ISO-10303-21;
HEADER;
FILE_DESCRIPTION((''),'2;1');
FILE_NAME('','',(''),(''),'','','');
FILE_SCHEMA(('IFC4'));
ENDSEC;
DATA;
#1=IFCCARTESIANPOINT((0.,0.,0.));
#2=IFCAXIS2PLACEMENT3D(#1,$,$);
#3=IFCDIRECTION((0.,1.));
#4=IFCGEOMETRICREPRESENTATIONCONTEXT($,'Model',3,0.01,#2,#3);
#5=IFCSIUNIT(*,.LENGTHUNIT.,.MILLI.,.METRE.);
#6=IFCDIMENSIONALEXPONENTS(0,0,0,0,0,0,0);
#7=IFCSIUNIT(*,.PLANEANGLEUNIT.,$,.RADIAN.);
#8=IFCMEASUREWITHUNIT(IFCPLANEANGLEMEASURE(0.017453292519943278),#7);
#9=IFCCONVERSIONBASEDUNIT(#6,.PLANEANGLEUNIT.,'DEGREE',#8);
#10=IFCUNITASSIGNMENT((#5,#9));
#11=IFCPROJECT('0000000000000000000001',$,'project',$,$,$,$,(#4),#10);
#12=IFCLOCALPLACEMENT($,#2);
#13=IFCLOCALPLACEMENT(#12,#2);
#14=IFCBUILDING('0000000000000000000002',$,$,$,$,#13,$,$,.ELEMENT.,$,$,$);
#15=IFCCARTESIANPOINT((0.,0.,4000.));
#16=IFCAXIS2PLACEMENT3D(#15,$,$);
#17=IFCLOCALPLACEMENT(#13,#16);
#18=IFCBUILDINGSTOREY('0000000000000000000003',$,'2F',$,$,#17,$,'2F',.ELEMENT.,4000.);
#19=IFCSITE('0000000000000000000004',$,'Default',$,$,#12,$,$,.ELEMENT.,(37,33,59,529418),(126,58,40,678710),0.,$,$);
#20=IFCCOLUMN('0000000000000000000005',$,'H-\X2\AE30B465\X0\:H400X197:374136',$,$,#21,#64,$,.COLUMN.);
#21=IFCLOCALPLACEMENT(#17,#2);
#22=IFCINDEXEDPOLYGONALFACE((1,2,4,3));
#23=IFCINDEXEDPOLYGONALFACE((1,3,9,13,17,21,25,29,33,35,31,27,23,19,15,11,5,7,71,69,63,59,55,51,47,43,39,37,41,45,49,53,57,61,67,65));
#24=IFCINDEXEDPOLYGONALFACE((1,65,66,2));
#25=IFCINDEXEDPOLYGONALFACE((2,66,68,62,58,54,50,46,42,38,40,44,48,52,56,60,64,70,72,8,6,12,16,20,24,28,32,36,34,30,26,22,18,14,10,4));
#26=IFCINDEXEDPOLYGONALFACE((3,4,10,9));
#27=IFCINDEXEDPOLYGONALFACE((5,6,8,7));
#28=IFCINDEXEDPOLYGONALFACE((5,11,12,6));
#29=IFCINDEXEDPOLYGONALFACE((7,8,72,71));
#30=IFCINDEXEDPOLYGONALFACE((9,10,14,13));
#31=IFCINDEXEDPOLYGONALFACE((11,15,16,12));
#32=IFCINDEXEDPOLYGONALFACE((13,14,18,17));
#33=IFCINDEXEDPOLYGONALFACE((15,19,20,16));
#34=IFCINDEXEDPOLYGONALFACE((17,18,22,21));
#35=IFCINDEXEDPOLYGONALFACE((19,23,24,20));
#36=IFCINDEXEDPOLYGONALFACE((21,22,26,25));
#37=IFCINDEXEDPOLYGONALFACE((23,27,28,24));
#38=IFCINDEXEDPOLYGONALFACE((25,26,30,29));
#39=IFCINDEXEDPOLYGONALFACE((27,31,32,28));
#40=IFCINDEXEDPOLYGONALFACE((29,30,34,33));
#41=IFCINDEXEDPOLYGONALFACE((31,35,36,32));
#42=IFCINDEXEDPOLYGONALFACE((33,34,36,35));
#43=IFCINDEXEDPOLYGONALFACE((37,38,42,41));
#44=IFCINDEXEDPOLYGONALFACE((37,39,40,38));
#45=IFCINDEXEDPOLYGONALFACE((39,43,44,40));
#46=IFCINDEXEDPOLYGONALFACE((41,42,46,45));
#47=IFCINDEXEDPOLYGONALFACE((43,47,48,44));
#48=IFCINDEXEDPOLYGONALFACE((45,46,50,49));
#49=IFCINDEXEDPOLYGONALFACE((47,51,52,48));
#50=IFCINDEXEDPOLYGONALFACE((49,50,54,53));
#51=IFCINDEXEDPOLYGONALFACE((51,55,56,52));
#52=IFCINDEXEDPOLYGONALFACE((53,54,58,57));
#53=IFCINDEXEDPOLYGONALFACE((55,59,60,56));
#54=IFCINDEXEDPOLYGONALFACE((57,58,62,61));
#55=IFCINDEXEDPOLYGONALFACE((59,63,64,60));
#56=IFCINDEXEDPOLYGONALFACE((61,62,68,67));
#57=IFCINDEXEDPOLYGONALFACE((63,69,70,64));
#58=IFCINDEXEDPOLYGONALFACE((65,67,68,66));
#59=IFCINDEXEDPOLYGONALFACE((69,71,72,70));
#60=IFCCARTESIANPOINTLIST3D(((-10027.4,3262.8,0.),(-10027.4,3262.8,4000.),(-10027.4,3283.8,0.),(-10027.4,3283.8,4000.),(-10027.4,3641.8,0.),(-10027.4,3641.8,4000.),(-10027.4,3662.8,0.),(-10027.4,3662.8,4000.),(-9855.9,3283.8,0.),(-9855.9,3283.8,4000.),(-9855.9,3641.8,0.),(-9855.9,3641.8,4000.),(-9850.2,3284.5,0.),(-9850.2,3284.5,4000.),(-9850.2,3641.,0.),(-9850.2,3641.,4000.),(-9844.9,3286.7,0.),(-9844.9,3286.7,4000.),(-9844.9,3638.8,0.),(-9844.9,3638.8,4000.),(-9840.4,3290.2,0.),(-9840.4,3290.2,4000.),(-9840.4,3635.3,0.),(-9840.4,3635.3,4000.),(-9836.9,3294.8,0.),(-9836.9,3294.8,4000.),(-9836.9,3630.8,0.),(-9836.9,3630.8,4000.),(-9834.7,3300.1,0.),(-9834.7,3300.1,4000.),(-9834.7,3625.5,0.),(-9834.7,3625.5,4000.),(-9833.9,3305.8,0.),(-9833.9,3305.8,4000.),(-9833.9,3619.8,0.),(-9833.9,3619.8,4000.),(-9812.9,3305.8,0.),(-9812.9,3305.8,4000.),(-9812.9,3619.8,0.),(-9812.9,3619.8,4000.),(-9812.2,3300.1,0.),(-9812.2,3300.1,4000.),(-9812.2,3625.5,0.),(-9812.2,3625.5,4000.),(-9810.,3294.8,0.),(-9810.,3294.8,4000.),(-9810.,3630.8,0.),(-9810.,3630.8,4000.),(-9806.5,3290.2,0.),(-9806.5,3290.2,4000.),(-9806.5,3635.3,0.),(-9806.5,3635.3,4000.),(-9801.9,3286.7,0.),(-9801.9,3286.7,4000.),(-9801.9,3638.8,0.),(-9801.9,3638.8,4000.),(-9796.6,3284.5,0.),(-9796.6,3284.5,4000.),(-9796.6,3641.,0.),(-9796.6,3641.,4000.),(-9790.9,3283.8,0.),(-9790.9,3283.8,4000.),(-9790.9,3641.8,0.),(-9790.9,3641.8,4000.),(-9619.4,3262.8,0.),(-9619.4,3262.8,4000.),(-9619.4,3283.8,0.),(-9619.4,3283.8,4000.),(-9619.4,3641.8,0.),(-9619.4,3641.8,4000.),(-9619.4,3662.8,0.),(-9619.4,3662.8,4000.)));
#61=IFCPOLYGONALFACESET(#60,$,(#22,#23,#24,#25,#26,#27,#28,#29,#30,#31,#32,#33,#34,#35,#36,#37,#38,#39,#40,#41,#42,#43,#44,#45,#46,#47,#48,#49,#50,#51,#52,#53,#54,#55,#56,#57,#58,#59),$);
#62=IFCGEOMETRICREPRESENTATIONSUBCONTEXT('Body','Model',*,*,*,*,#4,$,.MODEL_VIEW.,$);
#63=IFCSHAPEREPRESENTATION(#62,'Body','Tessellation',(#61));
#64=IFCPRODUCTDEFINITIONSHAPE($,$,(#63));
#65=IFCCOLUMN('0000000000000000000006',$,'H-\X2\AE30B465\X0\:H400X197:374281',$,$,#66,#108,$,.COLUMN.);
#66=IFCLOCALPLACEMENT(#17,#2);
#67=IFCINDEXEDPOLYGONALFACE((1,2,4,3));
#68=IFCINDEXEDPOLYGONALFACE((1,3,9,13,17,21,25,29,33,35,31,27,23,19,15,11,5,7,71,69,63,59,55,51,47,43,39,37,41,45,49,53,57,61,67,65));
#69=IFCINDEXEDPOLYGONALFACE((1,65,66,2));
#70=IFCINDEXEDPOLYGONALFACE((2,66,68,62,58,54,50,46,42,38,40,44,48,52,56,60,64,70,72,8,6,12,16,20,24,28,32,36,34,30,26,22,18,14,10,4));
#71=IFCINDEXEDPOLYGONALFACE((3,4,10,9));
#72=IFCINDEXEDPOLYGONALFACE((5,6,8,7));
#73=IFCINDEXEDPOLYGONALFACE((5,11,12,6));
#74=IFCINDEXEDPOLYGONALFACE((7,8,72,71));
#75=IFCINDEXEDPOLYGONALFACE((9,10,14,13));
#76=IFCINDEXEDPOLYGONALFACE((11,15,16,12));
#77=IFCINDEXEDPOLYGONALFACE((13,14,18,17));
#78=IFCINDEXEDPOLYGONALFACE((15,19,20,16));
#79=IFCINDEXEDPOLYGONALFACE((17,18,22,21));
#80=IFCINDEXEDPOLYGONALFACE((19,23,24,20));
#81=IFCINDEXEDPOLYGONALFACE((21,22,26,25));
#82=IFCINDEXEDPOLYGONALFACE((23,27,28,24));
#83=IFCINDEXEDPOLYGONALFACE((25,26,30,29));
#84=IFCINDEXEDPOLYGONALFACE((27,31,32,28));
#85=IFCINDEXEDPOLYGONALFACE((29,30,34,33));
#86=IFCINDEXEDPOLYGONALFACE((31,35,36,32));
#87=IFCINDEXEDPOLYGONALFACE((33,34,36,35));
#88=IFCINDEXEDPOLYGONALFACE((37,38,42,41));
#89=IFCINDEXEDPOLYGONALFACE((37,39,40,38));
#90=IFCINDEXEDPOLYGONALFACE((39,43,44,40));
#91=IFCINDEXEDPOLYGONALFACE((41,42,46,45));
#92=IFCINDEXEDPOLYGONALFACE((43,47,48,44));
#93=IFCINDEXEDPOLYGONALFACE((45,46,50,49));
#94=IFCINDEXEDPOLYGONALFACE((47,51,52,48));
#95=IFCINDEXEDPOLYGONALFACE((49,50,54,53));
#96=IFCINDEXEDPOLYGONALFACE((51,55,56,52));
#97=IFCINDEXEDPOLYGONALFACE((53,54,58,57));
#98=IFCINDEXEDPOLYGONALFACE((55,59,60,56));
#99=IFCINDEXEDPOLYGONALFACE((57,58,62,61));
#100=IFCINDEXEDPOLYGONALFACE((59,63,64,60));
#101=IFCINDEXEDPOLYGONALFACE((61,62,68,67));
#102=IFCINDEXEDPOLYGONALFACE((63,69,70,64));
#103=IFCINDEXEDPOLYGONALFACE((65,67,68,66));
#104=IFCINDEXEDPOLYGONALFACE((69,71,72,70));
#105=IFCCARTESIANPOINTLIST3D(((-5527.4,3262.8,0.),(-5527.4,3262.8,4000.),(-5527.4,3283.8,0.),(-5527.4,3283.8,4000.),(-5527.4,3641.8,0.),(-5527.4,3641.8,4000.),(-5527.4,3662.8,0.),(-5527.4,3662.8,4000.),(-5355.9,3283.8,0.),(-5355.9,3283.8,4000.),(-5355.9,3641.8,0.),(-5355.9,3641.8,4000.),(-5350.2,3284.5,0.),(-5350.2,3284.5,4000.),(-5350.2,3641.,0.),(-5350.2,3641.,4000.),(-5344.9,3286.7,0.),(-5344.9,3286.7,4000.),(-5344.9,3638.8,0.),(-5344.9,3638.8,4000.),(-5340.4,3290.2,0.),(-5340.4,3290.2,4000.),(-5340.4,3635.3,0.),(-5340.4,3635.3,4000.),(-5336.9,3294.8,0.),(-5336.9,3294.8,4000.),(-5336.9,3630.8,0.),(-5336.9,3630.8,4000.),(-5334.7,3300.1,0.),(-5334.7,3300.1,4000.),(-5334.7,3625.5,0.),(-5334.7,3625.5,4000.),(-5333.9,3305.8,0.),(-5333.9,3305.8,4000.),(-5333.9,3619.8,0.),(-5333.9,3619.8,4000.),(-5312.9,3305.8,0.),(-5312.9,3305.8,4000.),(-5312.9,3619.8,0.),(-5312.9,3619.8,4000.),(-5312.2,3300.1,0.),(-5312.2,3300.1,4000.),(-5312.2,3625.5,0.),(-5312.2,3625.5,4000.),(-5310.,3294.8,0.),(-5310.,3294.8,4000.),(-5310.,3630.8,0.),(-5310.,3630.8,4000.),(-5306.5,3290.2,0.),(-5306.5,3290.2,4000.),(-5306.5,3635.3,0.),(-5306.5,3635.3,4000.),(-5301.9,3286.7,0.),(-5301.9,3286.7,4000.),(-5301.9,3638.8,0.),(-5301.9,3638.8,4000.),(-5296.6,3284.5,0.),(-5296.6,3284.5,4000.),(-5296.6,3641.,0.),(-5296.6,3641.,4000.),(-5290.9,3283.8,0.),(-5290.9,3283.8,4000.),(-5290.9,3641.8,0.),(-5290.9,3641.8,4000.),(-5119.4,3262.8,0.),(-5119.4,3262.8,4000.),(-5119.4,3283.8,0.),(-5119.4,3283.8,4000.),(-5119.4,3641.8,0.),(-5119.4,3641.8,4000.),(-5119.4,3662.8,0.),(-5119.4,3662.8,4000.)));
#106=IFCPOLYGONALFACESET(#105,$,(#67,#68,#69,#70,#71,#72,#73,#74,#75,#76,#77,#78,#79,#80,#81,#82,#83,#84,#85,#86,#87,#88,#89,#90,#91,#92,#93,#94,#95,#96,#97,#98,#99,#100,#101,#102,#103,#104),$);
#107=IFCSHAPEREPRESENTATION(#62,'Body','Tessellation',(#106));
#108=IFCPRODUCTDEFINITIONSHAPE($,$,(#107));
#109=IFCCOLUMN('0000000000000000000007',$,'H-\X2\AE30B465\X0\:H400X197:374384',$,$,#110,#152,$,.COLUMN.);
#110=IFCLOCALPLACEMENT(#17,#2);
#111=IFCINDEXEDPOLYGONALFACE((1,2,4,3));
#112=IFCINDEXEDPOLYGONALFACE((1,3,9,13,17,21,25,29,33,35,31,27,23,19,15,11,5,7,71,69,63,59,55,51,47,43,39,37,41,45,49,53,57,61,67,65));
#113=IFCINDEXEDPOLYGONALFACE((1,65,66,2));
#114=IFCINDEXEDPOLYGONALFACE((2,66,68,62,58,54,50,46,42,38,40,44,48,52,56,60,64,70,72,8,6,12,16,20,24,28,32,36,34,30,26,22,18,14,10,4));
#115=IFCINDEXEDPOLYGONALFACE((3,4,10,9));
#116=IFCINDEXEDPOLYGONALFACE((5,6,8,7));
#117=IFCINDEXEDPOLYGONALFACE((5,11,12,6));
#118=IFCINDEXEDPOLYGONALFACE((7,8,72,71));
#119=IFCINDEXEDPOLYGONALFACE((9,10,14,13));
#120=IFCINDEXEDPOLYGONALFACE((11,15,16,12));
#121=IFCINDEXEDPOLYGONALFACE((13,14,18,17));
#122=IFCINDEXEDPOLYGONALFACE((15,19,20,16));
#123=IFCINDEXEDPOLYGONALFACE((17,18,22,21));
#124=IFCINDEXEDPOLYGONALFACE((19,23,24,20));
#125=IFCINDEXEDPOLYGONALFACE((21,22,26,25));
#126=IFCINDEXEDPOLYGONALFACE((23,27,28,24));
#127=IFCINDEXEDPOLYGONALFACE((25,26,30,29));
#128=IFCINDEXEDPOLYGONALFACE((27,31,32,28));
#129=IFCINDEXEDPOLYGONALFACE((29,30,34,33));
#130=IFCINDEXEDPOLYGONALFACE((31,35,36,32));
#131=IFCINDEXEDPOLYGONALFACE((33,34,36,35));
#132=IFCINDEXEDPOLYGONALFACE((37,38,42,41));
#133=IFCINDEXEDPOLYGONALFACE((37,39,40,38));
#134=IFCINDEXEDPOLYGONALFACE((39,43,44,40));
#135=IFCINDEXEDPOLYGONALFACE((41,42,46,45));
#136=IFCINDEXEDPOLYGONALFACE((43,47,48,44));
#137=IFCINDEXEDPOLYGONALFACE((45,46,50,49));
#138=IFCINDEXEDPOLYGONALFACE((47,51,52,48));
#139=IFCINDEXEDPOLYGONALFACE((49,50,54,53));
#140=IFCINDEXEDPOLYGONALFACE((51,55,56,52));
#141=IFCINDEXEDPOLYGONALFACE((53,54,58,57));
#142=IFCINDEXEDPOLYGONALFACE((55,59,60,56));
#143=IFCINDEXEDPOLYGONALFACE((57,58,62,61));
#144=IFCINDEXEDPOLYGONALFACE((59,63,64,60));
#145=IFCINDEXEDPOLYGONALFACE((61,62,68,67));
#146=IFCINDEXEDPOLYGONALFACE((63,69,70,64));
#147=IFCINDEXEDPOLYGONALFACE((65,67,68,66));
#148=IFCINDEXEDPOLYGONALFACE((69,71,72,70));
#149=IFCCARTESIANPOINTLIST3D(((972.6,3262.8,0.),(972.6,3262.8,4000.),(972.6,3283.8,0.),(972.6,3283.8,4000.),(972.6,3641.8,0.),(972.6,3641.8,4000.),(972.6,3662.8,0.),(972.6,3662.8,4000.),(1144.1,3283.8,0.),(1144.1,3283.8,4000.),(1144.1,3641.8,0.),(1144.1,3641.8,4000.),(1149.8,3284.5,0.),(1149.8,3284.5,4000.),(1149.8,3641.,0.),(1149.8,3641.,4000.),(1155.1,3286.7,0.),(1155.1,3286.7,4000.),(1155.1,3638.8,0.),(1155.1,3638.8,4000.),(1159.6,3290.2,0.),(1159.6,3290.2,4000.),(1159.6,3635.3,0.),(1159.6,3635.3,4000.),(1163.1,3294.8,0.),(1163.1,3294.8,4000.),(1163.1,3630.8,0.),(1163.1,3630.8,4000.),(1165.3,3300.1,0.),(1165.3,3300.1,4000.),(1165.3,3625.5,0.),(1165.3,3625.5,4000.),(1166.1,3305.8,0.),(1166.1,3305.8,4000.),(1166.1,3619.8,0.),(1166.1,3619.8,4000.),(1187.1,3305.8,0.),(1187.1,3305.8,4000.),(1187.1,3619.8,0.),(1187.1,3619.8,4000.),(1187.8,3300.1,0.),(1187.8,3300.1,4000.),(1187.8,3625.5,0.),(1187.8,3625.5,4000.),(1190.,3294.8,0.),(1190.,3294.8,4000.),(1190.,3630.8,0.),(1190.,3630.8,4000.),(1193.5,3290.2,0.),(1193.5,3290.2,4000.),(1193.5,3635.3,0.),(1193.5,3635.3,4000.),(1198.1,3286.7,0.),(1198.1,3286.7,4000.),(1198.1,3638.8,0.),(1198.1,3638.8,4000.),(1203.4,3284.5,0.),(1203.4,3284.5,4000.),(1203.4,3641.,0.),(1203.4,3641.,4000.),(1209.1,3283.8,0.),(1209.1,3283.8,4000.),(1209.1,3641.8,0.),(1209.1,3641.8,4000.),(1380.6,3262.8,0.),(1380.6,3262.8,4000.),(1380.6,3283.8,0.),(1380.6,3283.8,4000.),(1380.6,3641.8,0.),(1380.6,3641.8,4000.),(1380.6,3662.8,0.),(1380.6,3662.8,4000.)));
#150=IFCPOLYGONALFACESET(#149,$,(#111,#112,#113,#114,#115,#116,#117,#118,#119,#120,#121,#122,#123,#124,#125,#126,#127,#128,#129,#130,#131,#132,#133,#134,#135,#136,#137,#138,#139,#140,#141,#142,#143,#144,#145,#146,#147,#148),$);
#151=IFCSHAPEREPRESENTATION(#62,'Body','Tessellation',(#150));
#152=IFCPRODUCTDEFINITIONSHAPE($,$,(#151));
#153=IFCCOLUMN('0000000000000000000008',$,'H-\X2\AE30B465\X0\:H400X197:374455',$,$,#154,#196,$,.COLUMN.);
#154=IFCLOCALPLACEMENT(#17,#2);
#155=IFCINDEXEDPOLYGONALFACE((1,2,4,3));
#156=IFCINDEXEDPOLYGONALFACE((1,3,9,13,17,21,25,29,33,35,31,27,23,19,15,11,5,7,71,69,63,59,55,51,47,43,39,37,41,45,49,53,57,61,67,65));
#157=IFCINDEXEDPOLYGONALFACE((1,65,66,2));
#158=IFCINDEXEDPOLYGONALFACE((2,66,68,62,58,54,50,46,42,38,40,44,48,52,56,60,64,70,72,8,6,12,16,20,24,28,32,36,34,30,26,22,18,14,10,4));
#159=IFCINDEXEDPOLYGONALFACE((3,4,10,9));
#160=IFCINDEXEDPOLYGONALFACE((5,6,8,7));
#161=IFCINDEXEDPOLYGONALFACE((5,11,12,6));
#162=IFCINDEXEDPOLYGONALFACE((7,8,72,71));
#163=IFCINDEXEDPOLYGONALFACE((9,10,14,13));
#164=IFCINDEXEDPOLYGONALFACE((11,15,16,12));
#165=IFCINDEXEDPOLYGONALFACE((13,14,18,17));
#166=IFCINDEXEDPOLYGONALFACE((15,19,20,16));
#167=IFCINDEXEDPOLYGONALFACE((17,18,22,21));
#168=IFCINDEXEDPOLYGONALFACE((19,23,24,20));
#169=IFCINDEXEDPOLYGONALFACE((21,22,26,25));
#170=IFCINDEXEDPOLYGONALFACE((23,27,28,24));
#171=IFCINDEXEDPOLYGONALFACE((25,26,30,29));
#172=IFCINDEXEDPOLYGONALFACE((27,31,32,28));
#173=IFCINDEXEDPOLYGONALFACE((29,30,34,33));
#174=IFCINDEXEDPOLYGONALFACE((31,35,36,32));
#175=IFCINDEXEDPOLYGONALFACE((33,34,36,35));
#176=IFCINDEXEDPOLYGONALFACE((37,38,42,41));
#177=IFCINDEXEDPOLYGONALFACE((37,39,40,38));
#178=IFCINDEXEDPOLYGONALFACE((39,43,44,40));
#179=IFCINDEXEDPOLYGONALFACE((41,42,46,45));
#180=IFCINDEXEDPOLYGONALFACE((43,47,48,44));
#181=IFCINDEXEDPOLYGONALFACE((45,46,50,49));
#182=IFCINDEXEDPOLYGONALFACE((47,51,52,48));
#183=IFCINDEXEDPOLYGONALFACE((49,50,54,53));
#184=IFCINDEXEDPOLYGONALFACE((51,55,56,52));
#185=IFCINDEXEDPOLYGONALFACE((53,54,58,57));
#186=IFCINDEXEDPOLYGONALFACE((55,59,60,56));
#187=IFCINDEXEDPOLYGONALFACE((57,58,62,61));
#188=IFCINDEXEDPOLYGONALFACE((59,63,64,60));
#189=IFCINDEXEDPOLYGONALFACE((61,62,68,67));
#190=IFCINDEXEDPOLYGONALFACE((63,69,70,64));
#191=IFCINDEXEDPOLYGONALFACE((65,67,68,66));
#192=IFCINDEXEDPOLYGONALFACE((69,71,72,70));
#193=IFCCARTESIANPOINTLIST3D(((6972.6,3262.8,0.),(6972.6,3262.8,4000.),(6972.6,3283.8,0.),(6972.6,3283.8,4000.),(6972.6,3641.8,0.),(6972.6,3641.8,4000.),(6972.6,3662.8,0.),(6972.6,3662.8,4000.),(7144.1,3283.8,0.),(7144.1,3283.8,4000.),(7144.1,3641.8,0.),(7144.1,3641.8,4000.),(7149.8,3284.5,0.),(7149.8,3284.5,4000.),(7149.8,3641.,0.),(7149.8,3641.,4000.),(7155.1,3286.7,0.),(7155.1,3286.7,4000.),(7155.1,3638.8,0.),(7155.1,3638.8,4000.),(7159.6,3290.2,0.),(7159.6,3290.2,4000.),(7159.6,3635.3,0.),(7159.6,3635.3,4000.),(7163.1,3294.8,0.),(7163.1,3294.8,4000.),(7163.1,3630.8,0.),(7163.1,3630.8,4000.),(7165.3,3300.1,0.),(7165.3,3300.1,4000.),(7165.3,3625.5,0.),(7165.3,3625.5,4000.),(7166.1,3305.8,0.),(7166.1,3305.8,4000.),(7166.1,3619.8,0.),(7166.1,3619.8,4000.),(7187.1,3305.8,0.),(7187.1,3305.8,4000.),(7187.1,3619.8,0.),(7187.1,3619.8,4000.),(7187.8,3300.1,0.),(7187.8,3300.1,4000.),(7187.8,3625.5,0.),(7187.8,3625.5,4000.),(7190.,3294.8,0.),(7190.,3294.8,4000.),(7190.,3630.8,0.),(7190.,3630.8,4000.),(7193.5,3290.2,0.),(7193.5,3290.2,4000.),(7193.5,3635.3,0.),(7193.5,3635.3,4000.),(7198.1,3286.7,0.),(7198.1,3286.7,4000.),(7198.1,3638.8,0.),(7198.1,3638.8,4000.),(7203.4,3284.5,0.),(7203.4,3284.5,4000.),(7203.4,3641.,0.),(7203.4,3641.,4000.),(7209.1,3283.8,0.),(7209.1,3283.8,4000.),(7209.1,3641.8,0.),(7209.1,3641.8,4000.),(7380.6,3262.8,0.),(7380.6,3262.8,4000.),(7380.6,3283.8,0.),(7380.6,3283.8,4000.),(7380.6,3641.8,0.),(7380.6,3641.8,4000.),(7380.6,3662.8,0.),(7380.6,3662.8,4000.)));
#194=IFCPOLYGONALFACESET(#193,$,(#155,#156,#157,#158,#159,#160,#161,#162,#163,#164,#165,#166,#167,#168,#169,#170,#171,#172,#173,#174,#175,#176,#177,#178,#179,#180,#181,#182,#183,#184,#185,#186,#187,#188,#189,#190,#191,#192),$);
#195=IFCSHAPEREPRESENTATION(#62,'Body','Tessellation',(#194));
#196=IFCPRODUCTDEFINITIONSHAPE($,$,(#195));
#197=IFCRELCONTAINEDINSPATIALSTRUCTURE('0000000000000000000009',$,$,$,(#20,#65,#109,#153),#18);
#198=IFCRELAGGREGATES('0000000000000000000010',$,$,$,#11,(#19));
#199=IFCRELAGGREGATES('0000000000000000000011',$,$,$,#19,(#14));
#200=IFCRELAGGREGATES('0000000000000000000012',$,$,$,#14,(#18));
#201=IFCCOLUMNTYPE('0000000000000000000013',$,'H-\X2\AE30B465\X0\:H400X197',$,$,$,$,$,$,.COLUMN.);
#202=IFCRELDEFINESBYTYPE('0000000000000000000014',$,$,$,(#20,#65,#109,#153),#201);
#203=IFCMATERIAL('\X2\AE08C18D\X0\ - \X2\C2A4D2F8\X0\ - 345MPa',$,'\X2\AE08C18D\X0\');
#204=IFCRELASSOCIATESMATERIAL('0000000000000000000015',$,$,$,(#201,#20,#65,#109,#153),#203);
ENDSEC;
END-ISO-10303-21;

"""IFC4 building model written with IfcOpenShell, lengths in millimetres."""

from ifc_helpers import new_model, entity, si_unit, converted_unit, direction, frame, origin, place, context, subcontext, project, spatial, line, arc, indexed_curve, outline, extrude, source, transform, mapped, material, type_object, type_shapes, element, save


model = new_model("IFC4")

# Units and contexts
model_context = context("Model", 3, precision=0.01, world=origin(), true_north=direction((0.0, 1.0)))
body_context = subcontext(model_context, "Body", "Model", "MODEL_VIEW")
ifc_project = project(units=[si_unit("LENGTHUNIT", "METRE", prefix="MILLI"), converted_unit("PLANEANGLEUNIT", "DEGREE", entity("IfcPlaneAngleMeasure", 0.017453292519943278), si_unit("PLANEANGLEUNIT", "RADIAN"), dimensions=[0, 0, 0, 0, 0, 0, 0])], contexts=[model_context])

# Site, building, storey
site_placement = place(None, origin())
site = spatial("IfcSite", under=ifc_project, at=site_placement, Name="Default", CompositionType="ELEMENT", RefLatitude=(37, 33, 59, 529418), RefLongitude=(126, 58, 40, 678710), RefElevation=0.0)
building_placement = place(site_placement, origin())
building = spatial("IfcBuilding", under=site, at=building_placement, CompositionType="ELEMENT")
storey_placement = place(building_placement, frame((0.0, 0.0, 4000.0)))
storey = spatial("IfcBuildingStorey", under=building, at=storey_placement, Name="2F", LongName="2F", CompositionType="ELEMENT", Elevation=4000.0)

# Columns
ifc_material = material(Name="금속 - 스틸 - 345MPa", Category="금속")
column_type = type_object("IfcColumnType", Name="H-기둥:H400X197", PredefinedType="COLUMN", material=ifc_material)
shared_shape_1 = source(origin(), body_context, "Body", "SweptSolid", [
    extrude(outline(indexed_curve([(-204.0, -200.0), (204.0, -200.0), (204.0, -179.0), (32.5, -179.0), (16.9, -172.6), (10.5, -157.0), (10.5, 157.0), (16.9, 172.6), (32.5, 179.0), (204.0, 179.0), (204.0, 200.0), (-204.0, 200.0), (-204.0, 179.0), (-32.5, 179.0), (-16.9, 172.6), (-10.5, 157.0), (-10.5, -157.0), (-16.9, -172.6), (-32.5, -179.0), (-204.0, -179.0)], segments=[line(1, 2, 3, 4), arc(4, 5, 6), line(6, 7), arc(7, 8, 9), line(9, 10, 11, 12, 13, 14), arc(14, 15, 16), line(16, 17), arc(17, 18, 19), line(19, 20, 1)], self_intersect=False)), frame((0.0, 0.0, 4000.0), z_axis=(0.0, 0.0, 1.0), x_axis=(-1.0, 0.0, 0.0)), (0.0, 0.0, 1.0), 4000.0),
])
type_shapes(column_type, [shared_shape_1])
for number, where, name in (
    (1, (-9823.4, 3462.8, -4000.0), "H-기둥:H400X197:374136"),
    (2, (-5323.4, 3462.8, -4000.0), "H-기둥:H400X197:374281"),
    (3, (1176.6, 3462.8, -4000.0), "H-기둥:H400X197:374384"),
    (4, (7176.6, 3462.8, -4000.0), "H-기둥:H400X197:374455"),
):
    element("IfcColumn", number, at=place(storey_placement, frame(where)), inside=storey, type_object=column_type, material=ifc_material, Name=name, PredefinedType="COLUMN", context=body_context, shape_type="MappedRepresentation", body=[
        mapped(shared_shape_1, transform((0.0, 0.0, 0.0), scale=1.0)),
    ])

save(model, "model.ifc")
